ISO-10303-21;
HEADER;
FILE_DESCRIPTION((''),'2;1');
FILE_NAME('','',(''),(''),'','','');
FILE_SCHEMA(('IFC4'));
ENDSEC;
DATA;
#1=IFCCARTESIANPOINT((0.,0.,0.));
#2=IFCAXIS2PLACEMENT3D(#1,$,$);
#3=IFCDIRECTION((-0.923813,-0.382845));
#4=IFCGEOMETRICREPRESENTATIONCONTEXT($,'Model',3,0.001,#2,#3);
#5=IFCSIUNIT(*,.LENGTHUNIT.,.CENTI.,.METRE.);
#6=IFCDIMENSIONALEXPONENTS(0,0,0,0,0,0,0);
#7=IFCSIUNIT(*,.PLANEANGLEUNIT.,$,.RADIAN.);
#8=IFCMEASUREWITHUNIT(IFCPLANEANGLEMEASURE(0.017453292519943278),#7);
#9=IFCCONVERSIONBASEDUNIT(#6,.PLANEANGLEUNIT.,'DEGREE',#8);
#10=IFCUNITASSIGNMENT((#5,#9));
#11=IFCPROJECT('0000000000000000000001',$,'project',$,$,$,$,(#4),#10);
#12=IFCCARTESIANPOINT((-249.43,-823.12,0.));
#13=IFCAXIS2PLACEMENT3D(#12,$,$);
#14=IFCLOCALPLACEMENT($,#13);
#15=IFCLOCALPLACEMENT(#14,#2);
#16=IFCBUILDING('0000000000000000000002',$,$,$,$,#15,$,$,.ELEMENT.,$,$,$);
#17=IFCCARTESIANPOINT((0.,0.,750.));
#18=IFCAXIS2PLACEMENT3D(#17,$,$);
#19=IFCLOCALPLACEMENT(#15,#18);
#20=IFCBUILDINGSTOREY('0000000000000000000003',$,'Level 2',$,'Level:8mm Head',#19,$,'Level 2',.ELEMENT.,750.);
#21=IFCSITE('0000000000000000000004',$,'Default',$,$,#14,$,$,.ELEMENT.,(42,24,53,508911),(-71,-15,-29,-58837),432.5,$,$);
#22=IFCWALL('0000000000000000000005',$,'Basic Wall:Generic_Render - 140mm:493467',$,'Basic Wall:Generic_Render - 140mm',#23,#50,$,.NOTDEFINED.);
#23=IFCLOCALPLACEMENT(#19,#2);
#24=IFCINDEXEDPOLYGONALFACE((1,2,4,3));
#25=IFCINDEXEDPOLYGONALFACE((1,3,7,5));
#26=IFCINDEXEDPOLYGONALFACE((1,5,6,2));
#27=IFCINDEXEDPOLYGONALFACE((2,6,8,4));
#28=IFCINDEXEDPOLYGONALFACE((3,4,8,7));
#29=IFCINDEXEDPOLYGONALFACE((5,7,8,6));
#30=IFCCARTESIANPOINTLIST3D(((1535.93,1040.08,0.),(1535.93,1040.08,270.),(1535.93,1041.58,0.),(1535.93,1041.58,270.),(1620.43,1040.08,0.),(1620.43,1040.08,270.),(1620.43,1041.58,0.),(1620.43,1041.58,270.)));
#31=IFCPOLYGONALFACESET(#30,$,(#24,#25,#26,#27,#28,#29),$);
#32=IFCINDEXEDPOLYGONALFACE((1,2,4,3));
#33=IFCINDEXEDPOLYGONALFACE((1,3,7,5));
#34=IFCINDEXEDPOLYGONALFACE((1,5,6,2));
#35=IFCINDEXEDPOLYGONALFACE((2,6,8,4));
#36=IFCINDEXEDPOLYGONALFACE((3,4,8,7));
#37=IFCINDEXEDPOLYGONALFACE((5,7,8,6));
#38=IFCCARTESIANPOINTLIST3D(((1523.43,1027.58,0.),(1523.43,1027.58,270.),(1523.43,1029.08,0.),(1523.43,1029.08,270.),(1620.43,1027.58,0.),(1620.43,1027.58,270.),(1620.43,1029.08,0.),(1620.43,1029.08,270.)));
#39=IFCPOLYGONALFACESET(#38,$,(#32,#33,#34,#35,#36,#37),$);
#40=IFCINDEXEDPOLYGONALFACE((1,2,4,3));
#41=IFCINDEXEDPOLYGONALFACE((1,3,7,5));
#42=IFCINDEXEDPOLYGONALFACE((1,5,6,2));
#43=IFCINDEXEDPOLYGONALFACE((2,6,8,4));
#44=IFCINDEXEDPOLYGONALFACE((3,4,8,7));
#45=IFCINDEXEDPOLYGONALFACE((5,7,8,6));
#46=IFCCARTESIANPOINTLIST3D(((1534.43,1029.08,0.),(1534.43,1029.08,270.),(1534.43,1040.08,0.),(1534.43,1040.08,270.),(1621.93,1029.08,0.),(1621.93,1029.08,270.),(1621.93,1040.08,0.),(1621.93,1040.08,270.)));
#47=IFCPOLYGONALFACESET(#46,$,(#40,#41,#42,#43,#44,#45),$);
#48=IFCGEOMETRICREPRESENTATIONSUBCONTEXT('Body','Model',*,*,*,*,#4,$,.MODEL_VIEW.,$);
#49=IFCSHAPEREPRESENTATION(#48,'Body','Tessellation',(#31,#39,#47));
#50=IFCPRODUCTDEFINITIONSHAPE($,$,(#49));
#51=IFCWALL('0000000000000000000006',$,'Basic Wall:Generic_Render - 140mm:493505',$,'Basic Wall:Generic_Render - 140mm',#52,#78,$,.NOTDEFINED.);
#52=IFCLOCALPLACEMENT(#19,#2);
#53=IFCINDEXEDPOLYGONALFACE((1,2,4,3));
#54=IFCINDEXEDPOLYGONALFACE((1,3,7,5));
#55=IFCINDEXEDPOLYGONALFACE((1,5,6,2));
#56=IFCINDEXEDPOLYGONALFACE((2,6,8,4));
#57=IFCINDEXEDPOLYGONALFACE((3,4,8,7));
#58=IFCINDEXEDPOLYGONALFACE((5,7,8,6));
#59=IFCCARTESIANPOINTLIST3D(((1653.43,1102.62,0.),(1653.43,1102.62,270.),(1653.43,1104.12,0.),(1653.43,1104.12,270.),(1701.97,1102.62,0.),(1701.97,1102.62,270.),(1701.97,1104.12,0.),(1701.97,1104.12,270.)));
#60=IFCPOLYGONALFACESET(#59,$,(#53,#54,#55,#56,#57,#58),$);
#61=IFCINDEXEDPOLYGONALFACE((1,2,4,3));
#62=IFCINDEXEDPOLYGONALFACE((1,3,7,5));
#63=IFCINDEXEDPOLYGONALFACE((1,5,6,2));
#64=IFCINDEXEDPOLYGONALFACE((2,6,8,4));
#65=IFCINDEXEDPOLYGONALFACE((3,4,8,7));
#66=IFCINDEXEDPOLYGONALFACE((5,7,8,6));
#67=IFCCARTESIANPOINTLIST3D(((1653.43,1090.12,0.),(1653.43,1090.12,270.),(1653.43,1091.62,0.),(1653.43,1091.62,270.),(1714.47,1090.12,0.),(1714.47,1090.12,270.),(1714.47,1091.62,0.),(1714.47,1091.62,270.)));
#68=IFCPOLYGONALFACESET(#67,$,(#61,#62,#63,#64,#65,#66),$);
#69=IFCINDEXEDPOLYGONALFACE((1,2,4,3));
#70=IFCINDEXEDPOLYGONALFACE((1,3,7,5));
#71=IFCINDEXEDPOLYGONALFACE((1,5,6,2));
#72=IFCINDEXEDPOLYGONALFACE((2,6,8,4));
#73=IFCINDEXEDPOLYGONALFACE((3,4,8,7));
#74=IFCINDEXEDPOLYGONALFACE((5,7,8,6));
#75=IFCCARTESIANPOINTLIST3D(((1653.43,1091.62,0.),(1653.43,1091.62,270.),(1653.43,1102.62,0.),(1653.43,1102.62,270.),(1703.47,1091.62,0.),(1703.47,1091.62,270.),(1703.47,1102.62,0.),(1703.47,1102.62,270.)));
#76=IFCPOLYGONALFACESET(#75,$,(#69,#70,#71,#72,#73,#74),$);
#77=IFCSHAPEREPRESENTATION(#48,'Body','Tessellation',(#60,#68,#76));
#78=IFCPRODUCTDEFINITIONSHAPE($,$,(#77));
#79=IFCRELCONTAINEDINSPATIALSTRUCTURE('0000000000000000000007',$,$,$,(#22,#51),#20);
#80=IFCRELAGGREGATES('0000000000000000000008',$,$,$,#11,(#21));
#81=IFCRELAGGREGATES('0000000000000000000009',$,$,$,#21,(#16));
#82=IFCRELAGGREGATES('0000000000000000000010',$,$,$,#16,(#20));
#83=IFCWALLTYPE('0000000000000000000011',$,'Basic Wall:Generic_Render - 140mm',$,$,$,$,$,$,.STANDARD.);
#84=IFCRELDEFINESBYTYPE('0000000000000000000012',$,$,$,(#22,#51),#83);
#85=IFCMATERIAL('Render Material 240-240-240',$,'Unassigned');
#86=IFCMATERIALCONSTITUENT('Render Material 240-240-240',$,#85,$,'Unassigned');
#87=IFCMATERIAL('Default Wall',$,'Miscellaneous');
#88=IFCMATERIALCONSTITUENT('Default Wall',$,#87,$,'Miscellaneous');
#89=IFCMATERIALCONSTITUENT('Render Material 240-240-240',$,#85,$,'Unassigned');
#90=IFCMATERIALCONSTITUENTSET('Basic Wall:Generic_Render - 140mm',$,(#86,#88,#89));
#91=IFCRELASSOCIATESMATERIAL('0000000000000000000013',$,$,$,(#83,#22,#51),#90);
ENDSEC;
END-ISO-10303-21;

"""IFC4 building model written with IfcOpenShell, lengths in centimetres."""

from ifc_helpers import new_model, entity, si_unit, converted_unit, direction, frame, origin, place, context, subcontext, project, spatial, indexed_curve, outline, extrude, material, constituent, constituent_set, type_object, element, save


model = new_model("IFC4")

# Units and contexts
model_context = context("Model", 3, precision=0.001, world=origin(), true_north=direction((-0.923813, -0.382845)))
body_context = subcontext(model_context, "Body", "Model", "MODEL_VIEW")
ifc_project = project(units=[si_unit("LENGTHUNIT", "METRE", prefix="CENTI"), converted_unit("PLANEANGLEUNIT", "DEGREE", entity("IfcPlaneAngleMeasure", 0.017453292519943278), si_unit("PLANEANGLEUNIT", "RADIAN"), dimensions=[0, 0, 0, 0, 0, 0, 0])], contexts=[model_context])

# Site, building, storey
site_placement = place(None, frame((-249.43, -823.12, 0.0)))
site = spatial("IfcSite", under=ifc_project, at=site_placement, Name="Default", CompositionType="ELEMENT", RefLatitude=(42, 24, 53, 508911), RefLongitude=(-71, -15, -29, -58837), RefElevation=432.5)
building_placement = place(site_placement, origin())
building = spatial("IfcBuilding", under=site, at=building_placement, CompositionType="ELEMENT")
storey_placement = place(building_placement, frame((0.0, 0.0, 750.0)))
storey = spatial("IfcBuildingStorey", under=building, at=storey_placement, Name="Level 2", ObjectType="Level:8mm Head", LongName="Level 2", CompositionType="ELEMENT", Elevation=750.0)

# Walls
ifc_material_1 = material(Name="Render Material 240-240-240", Category="Unassigned")
ifc_material_2 = material(Name="Default Wall", Category="Miscellaneous")
ifc_constituent_1 = constituent(ifc_material_1, Name="Render Material 240-240-240", Category="Unassigned")
ifc_constituent_2 = constituent(ifc_material_2, Name="Default Wall", Category="Miscellaneous")
ifc_constituent_3 = constituent(ifc_material_1, Name="Render Material 240-240-240", Category="Unassigned")
ifc_constituent_set_1 = constituent_set(constituents=[ifc_constituent_1, ifc_constituent_2, ifc_constituent_3], Name="Basic Wall:Generic_Render - 140mm")
wall_type_1 = type_object("IfcWallType", Name="Basic Wall:Generic_Render - 140mm", PredefinedType="STANDARD", material=ifc_constituent_set_1)
wall_1_placement = place(storey_placement, frame((1535.93, 1034.58, 0.0)))
element("IfcWall", 1, at=wall_1_placement, inside=storey, type_object=wall_type_1, material=ifc_constituent_set_1, Name="Basic Wall:Generic_Render - 140mm:493467", ObjectType="Basic Wall:Generic_Render - 140mm", PredefinedType="NOTDEFINED", context=body_context, shape_type="SweptSolid", body=[
    extrude(outline(indexed_curve([(-0.75, -42.25), (0.75, -42.25), (0.75, 42.25), (-0.75, 42.25), (-0.75, -42.25)], self_intersect=False)), frame((42.25, 6.25, 0.0), z_axis=(0.0, 0.0, 1.0), x_axis=(0.0, -1.0, 0.0)), (0.0, 0.0, 1.0), 270.0),
    extrude(outline(indexed_curve([(-0.75, -48.5), (0.75, -48.5), (0.75, 48.5), (-0.75, 48.5), (-0.75, -48.5)], self_intersect=False)), frame((36.0, -6.25, 0.0), z_axis=(0.0, 0.0, 1.0), x_axis=(0.0, 1.0, 0.0)), (0.0, 0.0, 1.0), 270.0),
    extrude(outline(indexed_curve([(-43.75, -5.5), (43.75, -5.5), (43.75, 5.5), (-43.75, 5.5), (-43.75, -5.5)], self_intersect=False)), frame((42.25, 0.0, 0.0)), (0.0, 0.0, 1.0), 270.0),
])
wall_2_placement = place(storey_placement, frame((1701.97, 1097.12, 0.0), z_axis=(0.0, 0.0, 1.0), x_axis=(-1.0, 0.0, 0.0)))
element("IfcWall", 2, at=wall_2_placement, inside=storey, type_object=wall_type_1, material=ifc_constituent_set_1, Name="Basic Wall:Generic_Render - 140mm:493505", ObjectType="Basic Wall:Generic_Render - 140mm", PredefinedType="NOTDEFINED", context=body_context, shape_type="SweptSolid", body=[
    extrude(outline(indexed_curve([(-0.75, -24.27), (0.75, -24.27), (0.75, 24.27), (-0.75, 24.27), (-0.75, -24.27)], self_intersect=False)), frame((24.27, -6.25, 0.0), z_axis=(0.0, 0.0, 1.0), x_axis=(0.0, 1.0, 0.0)), (0.0, 0.0, 1.0), 270.0),
    extrude(outline(indexed_curve([(-0.75, -30.52), (0.75, -30.52), (0.75, 30.52), (-0.75, 30.52), (-0.75, -30.52)], self_intersect=False)), frame((18.02, 6.25, 0.0), z_axis=(0.0, 0.0, 1.0), x_axis=(0.0, -1.0, 0.0)), (0.0, 0.0, 1.0), 270.0),
    extrude(outline(indexed_curve([(-25.02, -5.5), (25.02, -5.5), (25.02, 5.5), (-25.02, 5.5), (-25.02, -5.5)], self_intersect=False)), frame((23.52, 0.0, 0.0)), (0.0, 0.0, 1.0), 270.0),
])

save(model, "model.ifc")
